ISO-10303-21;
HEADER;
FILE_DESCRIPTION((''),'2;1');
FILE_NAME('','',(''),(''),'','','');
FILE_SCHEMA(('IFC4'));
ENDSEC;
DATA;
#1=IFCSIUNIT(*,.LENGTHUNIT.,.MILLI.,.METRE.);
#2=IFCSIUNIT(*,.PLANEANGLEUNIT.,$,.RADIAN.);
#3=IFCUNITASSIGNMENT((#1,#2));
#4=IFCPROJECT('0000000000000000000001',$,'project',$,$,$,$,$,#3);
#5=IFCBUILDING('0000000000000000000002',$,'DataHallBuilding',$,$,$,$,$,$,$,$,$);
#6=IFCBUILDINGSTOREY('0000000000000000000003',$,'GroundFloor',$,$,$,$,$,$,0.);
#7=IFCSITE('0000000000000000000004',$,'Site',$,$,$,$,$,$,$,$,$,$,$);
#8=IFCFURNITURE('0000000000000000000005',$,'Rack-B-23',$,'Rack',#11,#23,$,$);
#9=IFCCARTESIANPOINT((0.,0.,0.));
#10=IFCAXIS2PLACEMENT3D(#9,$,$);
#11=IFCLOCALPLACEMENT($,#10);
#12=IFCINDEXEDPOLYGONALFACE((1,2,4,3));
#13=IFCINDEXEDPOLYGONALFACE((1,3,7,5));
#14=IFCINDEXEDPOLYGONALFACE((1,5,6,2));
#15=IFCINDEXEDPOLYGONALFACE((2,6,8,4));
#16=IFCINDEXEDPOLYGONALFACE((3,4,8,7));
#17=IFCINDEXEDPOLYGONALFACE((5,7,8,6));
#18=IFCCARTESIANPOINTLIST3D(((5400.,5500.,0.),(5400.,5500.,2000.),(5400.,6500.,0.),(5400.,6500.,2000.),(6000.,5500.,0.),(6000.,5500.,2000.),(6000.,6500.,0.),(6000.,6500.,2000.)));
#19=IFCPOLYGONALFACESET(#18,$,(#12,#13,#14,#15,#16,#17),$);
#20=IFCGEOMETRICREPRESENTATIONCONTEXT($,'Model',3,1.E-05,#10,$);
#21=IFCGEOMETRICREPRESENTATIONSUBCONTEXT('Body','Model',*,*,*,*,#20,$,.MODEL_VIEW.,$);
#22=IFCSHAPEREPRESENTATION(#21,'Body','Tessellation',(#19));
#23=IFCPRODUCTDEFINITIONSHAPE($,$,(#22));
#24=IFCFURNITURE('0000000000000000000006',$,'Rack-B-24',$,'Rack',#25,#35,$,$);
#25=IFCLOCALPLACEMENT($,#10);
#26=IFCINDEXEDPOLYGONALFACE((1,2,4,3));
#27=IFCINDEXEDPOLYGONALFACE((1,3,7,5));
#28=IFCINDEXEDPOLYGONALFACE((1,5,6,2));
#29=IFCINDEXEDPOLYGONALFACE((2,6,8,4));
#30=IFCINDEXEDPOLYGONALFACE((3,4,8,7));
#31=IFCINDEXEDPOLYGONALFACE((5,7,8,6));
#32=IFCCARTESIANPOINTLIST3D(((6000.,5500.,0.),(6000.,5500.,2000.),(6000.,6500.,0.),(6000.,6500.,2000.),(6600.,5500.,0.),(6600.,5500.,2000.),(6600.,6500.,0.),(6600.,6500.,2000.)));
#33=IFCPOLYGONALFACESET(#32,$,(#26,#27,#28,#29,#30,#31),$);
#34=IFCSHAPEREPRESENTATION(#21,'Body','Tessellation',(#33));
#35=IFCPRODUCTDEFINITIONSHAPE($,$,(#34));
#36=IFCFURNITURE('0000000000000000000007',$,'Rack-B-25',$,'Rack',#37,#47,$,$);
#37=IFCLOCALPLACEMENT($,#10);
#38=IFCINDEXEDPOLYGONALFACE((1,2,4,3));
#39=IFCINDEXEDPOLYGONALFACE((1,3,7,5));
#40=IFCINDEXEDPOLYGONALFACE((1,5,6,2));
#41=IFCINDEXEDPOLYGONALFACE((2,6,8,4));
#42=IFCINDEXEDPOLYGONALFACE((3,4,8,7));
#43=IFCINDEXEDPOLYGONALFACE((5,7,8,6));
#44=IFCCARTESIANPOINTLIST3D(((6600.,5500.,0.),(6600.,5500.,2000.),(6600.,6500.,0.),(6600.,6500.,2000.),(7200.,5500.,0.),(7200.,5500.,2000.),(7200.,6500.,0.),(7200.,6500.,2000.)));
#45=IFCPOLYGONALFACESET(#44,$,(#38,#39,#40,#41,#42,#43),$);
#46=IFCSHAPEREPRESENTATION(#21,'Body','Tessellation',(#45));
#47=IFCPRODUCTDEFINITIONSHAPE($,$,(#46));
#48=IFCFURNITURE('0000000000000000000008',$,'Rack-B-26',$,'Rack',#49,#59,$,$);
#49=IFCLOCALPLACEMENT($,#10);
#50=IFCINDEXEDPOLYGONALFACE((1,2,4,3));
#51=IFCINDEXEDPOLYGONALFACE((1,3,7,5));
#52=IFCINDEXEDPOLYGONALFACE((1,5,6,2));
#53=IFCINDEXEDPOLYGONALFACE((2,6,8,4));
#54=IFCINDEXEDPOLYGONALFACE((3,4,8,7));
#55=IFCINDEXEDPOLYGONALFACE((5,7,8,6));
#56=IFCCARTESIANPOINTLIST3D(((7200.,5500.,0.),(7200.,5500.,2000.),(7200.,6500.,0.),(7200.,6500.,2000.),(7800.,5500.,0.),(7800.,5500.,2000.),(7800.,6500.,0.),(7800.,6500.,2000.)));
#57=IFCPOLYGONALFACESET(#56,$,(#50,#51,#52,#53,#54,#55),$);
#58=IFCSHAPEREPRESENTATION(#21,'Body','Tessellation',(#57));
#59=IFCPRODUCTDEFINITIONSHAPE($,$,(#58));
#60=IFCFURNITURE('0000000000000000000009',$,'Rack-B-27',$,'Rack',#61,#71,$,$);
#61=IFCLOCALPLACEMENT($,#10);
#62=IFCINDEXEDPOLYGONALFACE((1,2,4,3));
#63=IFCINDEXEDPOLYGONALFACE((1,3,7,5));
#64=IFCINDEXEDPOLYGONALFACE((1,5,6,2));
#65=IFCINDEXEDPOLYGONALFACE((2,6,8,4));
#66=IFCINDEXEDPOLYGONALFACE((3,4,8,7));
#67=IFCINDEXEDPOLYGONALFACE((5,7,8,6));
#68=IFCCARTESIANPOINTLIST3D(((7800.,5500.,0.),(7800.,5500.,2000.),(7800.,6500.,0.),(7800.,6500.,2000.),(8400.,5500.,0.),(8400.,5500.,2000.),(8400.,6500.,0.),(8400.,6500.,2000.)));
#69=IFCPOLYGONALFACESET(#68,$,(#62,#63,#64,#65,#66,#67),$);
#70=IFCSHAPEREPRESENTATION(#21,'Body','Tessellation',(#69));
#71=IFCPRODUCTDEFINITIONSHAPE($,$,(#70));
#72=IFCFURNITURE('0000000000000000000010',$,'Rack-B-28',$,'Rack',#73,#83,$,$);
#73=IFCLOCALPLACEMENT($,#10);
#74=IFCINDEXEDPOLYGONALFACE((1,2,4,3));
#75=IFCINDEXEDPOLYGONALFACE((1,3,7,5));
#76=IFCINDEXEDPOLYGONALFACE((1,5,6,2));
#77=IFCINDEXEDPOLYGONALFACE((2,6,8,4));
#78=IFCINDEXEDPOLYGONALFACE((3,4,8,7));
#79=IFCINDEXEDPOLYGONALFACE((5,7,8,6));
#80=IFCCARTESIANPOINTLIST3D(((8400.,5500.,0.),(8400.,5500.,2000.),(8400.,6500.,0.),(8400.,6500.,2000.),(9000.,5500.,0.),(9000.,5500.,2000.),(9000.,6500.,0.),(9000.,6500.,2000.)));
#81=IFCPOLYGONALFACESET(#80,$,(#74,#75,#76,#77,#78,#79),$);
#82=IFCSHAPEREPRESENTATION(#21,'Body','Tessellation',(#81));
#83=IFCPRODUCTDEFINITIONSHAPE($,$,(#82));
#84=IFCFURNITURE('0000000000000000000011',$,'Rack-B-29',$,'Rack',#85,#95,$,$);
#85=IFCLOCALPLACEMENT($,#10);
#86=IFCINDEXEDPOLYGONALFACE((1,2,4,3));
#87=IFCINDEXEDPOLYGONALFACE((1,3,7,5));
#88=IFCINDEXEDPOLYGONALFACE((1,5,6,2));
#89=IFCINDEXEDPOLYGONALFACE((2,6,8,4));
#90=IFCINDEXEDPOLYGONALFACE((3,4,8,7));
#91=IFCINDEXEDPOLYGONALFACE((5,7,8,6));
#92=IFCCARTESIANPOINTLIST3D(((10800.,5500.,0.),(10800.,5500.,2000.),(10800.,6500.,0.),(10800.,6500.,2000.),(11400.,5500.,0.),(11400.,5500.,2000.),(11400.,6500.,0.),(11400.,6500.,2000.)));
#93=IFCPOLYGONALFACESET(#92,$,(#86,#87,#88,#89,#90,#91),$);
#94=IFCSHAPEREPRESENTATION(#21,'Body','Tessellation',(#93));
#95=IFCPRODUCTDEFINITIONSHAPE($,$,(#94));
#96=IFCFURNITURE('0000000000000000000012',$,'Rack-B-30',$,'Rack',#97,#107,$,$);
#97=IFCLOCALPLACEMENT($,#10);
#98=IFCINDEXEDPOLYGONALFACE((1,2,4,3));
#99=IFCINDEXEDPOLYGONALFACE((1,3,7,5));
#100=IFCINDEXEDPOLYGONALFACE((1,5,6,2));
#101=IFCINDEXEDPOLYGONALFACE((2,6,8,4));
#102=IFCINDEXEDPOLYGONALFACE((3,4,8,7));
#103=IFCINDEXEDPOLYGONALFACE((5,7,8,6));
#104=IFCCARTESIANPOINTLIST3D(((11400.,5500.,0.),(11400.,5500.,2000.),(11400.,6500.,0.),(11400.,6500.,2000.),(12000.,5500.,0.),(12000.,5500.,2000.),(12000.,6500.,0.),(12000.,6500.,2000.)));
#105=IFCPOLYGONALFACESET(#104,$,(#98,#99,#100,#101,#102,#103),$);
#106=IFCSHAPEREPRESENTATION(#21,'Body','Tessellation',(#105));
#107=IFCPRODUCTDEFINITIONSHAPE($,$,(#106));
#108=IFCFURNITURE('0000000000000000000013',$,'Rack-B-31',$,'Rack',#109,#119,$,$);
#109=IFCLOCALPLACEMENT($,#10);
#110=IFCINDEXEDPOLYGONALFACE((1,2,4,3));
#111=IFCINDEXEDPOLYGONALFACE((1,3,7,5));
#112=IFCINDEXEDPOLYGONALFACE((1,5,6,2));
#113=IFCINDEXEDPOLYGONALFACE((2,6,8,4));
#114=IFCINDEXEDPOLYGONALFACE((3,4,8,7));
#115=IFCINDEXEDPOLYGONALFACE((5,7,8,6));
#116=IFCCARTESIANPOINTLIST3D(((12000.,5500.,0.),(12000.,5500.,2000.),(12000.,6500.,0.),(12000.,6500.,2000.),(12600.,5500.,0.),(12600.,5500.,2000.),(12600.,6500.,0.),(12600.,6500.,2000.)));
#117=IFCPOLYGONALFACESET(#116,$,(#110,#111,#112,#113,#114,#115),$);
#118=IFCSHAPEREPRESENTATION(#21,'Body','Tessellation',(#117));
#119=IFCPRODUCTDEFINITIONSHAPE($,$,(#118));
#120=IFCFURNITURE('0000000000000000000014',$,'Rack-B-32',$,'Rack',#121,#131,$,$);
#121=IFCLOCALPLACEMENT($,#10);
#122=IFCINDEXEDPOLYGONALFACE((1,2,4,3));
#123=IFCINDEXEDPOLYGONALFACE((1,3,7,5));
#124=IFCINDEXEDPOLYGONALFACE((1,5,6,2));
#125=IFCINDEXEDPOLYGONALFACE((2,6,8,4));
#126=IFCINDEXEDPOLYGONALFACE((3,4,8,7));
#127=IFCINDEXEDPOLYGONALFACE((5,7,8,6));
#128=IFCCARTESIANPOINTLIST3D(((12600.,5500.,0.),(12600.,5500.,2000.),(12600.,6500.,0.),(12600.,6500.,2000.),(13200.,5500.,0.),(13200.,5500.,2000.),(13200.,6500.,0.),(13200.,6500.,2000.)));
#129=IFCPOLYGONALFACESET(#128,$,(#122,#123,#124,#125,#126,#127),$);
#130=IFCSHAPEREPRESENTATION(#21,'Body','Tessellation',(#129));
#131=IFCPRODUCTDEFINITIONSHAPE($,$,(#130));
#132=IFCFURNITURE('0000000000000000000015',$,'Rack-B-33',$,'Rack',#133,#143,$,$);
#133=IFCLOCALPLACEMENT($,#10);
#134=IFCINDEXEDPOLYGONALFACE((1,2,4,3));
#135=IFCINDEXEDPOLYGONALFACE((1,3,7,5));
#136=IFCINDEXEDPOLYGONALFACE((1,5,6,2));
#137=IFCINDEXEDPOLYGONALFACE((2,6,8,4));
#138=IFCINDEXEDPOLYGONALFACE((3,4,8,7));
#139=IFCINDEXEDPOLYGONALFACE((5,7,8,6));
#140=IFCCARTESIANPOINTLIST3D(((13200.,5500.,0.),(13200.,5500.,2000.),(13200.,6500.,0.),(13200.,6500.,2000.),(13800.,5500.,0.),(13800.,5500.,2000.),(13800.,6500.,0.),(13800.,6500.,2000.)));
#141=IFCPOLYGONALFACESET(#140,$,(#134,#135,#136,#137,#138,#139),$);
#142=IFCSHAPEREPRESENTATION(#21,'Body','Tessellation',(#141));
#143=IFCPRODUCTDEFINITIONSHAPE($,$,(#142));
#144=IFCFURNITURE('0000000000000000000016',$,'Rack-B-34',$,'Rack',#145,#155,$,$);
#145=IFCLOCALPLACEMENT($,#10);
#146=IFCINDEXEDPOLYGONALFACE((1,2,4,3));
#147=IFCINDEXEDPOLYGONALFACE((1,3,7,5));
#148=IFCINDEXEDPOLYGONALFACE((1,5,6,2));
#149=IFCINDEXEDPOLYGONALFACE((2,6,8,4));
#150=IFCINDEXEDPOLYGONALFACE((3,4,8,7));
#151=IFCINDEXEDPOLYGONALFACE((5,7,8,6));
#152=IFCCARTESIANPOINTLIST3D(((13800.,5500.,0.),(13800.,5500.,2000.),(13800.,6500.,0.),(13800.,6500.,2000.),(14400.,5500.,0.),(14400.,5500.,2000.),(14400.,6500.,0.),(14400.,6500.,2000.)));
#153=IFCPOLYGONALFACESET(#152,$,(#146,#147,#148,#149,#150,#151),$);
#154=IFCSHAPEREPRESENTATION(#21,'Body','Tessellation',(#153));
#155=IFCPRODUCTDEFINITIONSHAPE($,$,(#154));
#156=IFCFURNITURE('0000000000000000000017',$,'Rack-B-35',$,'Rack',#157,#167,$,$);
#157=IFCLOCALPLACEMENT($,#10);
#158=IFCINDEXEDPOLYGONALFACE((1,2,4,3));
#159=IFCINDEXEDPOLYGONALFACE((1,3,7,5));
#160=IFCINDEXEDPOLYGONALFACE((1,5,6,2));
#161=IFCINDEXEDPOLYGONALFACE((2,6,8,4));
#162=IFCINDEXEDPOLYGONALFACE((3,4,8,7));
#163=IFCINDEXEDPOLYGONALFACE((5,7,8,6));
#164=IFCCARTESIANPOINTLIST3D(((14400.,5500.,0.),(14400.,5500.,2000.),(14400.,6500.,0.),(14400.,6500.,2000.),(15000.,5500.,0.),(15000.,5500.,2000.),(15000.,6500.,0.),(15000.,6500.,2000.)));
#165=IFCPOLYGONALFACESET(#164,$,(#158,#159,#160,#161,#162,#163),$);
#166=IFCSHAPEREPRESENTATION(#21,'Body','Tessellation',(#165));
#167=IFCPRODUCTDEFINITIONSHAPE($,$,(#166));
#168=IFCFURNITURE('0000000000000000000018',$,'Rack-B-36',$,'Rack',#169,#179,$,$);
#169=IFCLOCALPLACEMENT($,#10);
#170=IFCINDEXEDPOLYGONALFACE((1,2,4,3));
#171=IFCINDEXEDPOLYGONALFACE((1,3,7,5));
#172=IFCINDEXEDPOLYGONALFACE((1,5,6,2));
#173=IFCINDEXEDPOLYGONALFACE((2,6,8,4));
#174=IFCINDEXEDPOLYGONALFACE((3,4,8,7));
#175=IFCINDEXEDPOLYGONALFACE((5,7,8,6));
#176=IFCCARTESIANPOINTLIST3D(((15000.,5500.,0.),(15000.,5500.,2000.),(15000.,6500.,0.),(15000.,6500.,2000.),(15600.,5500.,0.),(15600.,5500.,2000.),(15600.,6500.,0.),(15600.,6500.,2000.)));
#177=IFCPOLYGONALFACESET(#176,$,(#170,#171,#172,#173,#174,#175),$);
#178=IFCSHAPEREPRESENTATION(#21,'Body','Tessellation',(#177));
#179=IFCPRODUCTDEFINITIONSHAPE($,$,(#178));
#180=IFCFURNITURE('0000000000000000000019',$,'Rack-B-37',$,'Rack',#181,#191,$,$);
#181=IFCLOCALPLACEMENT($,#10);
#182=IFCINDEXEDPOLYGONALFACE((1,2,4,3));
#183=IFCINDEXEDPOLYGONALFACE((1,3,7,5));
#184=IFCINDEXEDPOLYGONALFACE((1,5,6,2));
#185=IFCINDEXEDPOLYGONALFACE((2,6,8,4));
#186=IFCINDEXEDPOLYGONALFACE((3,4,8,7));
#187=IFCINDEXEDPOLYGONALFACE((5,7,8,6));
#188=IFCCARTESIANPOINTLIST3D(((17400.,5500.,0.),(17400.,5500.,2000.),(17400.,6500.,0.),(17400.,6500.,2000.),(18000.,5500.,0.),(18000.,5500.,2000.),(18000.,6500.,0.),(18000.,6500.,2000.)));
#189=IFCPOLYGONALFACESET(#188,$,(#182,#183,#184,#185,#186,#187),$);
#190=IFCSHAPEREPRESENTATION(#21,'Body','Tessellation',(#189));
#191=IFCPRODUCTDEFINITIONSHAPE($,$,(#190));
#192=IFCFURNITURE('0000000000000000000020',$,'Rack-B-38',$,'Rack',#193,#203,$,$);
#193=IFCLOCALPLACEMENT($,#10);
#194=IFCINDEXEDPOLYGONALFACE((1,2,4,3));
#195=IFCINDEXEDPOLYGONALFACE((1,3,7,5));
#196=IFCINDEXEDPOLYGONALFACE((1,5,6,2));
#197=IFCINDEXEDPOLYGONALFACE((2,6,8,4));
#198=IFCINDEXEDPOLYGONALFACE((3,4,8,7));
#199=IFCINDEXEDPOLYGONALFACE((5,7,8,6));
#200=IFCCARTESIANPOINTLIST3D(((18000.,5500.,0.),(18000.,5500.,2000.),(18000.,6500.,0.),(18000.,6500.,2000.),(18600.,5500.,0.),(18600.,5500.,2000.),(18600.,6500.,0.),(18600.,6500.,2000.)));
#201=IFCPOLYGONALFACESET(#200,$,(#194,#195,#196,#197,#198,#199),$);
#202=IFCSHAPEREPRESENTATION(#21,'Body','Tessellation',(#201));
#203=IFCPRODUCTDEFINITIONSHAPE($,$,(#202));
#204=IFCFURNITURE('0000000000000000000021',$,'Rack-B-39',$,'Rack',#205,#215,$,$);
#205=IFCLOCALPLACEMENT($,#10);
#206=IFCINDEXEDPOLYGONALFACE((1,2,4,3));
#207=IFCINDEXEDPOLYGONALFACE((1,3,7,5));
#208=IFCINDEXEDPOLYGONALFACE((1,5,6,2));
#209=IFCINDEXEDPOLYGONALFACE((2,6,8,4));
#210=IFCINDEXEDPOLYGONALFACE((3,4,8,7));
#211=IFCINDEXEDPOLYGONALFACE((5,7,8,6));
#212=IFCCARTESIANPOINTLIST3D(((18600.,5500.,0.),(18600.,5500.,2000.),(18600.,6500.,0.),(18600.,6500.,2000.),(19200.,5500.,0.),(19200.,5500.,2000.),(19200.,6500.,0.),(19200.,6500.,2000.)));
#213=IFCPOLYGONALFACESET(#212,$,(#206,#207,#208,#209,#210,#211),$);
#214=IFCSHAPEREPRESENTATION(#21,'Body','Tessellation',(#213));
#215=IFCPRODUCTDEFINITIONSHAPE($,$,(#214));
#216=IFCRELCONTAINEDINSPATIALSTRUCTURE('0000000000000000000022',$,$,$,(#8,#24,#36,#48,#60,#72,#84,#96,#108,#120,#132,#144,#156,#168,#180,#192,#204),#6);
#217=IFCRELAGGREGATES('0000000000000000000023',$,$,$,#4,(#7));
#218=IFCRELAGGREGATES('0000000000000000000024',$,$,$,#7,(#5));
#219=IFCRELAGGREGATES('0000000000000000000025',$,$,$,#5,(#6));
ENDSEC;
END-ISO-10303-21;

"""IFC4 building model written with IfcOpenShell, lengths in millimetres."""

from ifc_helpers import new_model, si_unit, frame, origin, place, context, subcontext, project, spatial, rectangle, extrude, element, save


model = new_model("IFC4")

# Units and contexts
model_context = context("Model", 3, precision=1e-05, world=origin())
body_context = subcontext(model_context, "Body", "Model", "MODEL_VIEW")
ifc_project = project(units=[si_unit("LENGTHUNIT", "METRE", prefix="MILLI"), si_unit("PLANEANGLEUNIT", "RADIAN")])

# Site, building, storey
site = spatial("IfcSite", under=ifc_project, Name="Site")
building = spatial("IfcBuilding", under=site, Name="DataHallBuilding")
storey = spatial("IfcBuildingStorey", under=building, Name="GroundFloor", Elevation=0.0)

# Furniture
furniture_1_placement = place(None, origin())
element("IfcFurniture", 1, at=furniture_1_placement, inside=storey, Name="Rack-B-23", ObjectType="Rack", context=body_context, shape_type="SweptSolid", body=[
    extrude(rectangle(XDim=600.0, YDim=1000.0), frame((5700.0, 6000.0, 0.0), z_axis=(0.0, 0.0, 1.0), x_axis=(1.0, 0.0, 0.0)), (0.0, 0.0, 1.0), 2000.0),
])
furniture_2_placement = place(None, origin())
element("IfcFurniture", 2, at=furniture_2_placement, inside=storey, Name="Rack-B-24", ObjectType="Rack", context=body_context, shape_type="SweptSolid", body=[
    extrude(rectangle(XDim=600.0, YDim=1000.0), frame((6300.0, 6000.0, 0.0), z_axis=(0.0, 0.0, 1.0), x_axis=(1.0, 0.0, 0.0)), (0.0, 0.0, 1.0), 2000.0),
])
furniture_3_placement = place(None, origin())
element("IfcFurniture", 3, at=furniture_3_placement, inside=storey, Name="Rack-B-25", ObjectType="Rack", context=body_context, shape_type="SweptSolid", body=[
    extrude(rectangle(XDim=600.0, YDim=1000.0), frame((6900.0, 6000.0, 0.0), z_axis=(0.0, 0.0, 1.0), x_axis=(1.0, 0.0, 0.0)), (0.0, 0.0, 1.0), 2000.0),
])
furniture_4_placement = place(None, origin())
element("IfcFurniture", 4, at=furniture_4_placement, inside=storey, Name="Rack-B-26", ObjectType="Rack", context=body_context, shape_type="SweptSolid", body=[
    extrude(rectangle(XDim=600.0, YDim=1000.0), frame((7500.0, 6000.0, 0.0), z_axis=(0.0, 0.0, 1.0), x_axis=(1.0, 0.0, 0.0)), (0.0, 0.0, 1.0), 2000.0),
])
furniture_5_placement = place(None, origin())
element("IfcFurniture", 5, at=furniture_5_placement, inside=storey, Name="Rack-B-27", ObjectType="Rack", context=body_context, shape_type="SweptSolid", body=[
    extrude(rectangle(XDim=600.0, YDim=1000.0), frame((8100.0, 6000.0, 0.0), z_axis=(0.0, 0.0, 1.0), x_axis=(1.0, 0.0, 0.0)), (0.0, 0.0, 1.0), 2000.0),
])
furniture_6_placement = place(None, origin())
element("IfcFurniture", 6, at=furniture_6_placement, inside=storey, Name="Rack-B-28", ObjectType="Rack", context=body_context, shape_type="SweptSolid", body=[
    extrude(rectangle(XDim=600.0, YDim=1000.0), frame((8700.0, 6000.0, 0.0), z_axis=(0.0, 0.0, 1.0), x_axis=(1.0, 0.0, 0.0)), (0.0, 0.0, 1.0), 2000.0),
])
furniture_7_placement = place(None, origin())
element("IfcFurniture", 7, at=furniture_7_placement, inside=storey, Name="Rack-B-29", ObjectType="Rack", context=body_context, shape_type="SweptSolid", body=[
    extrude(rectangle(XDim=600.0, YDim=1000.0), frame((11100.0, 6000.0, 0.0), z_axis=(0.0, 0.0, 1.0), x_axis=(1.0, 0.0, 0.0)), (0.0, 0.0, 1.0), 2000.0),
])
furniture_8_placement = place(None, origin())
element("IfcFurniture", 8, at=furniture_8_placement, inside=storey, Name="Rack-B-30", ObjectType="Rack", context=body_context, shape_type="SweptSolid", body=[
    extrude(rectangle(XDim=600.0, YDim=1000.0), frame((11700.0, 6000.0, 0.0), z_axis=(0.0, 0.0, 1.0), x_axis=(1.0, 0.0, 0.0)), (0.0, 0.0, 1.0), 2000.0),
])
furniture_9_placement = place(None, origin())
element("IfcFurniture", 9, at=furniture_9_placement, inside=storey, Name="Rack-B-31", ObjectType="Rack", context=body_context, shape_type="SweptSolid", body=[
    extrude(rectangle(XDim=600.0, YDim=1000.0), frame((12300.0, 6000.0, 0.0), z_axis=(0.0, 0.0, 1.0), x_axis=(1.0, 0.0, 0.0)), (0.0, 0.0, 1.0), 2000.0),
])
furniture_10_placement = place(None, origin())
element("IfcFurniture", 10, at=furniture_10_placement, inside=storey, Name="Rack-B-32", ObjectType="Rack", context=body_context, shape_type="SweptSolid", body=[
    extrude(rectangle(XDim=600.0, YDim=1000.0), frame((12900.0, 6000.0, 0.0), z_axis=(0.0, 0.0, 1.0), x_axis=(1.0, 0.0, 0.0)), (0.0, 0.0, 1.0), 2000.0),
])
furniture_11_placement = place(None, origin())
element("IfcFurniture", 11, at=furniture_11_placement, inside=storey, Name="Rack-B-33", ObjectType="Rack", context=body_context, shape_type="SweptSolid", body=[
    extrude(rectangle(XDim=600.0, YDim=1000.0), frame((13500.0, 6000.0, 0.0), z_axis=(0.0, 0.0, 1.0), x_axis=(1.0, 0.0, 0.0)), (0.0, 0.0, 1.0), 2000.0),
])
furniture_12_placement = place(None, origin())
element("IfcFurniture", 12, at=furniture_12_placement, inside=storey, Name="Rack-B-34", ObjectType="Rack", context=body_context, shape_type="SweptSolid", body=[
    extrude(rectangle(XDim=600.0, YDim=1000.0), frame((14100.0, 6000.0, 0.0), z_axis=(0.0, 0.0, 1.0), x_axis=(1.0, 0.0, 0.0)), (0.0, 0.0, 1.0), 2000.0),
])
furniture_13_placement = place(None, origin())
element("IfcFurniture", 13, at=furniture_13_placement, inside=storey, Name="Rack-B-35", ObjectType="Rack", context=body_context, shape_type="SweptSolid", body=[
    extrude(rectangle(XDim=600.0, YDim=1000.0), frame((14700.0, 6000.0, 0.0), z_axis=(0.0, 0.0, 1.0), x_axis=(1.0, 0.0, 0.0)), (0.0, 0.0, 1.0), 2000.0),
])
furniture_14_placement = place(None, origin())
element("IfcFurniture", 14, at=furniture_14_placement, inside=storey, Name="Rack-B-36", ObjectType="Rack", context=body_context, shape_type="SweptSolid", body=[
    extrude(rectangle(XDim=600.0, YDim=1000.0), frame((15300.0, 6000.0, 0.0), z_axis=(0.0, 0.0, 1.0), x_axis=(1.0, 0.0, 0.0)), (0.0, 0.0, 1.0), 2000.0),
])
furniture_15_placement = place(None, origin())
element("IfcFurniture", 15, at=furniture_15_placement, inside=storey, Name="Rack-B-37", ObjectType="Rack", context=body_context, shape_type="SweptSolid", body=[
    extrude(rectangle(XDim=600.0, YDim=1000.0), frame((17700.0, 6000.0, 0.0), z_axis=(0.0, 0.0, 1.0), x_axis=(1.0, 0.0, 0.0)), (0.0, 0.0, 1.0), 2000.0),
])
furniture_16_placement = place(None, origin())
element("IfcFurniture", 16, at=furniture_16_placement, inside=storey, Name="Rack-B-38", ObjectType="Rack", context=body_context, shape_type="SweptSolid", body=[
    extrude(rectangle(XDim=600.0, YDim=1000.0), frame((18300.0, 6000.0, 0.0), z_axis=(0.0, 0.0, 1.0), x_axis=(1.0, 0.0, 0.0)), (0.0, 0.0, 1.0), 2000.0),
])
furniture_17_placement = place(None, origin())
element("IfcFurniture", 17, at=furniture_17_placement, inside=storey, Name="Rack-B-39", ObjectType="Rack", context=body_context, shape_type="SweptSolid", body=[
    extrude(rectangle(XDim=600.0, YDim=1000.0), frame((18900.0, 6000.0, 0.0), z_axis=(0.0, 0.0, 1.0), x_axis=(1.0, 0.0, 0.0)), (0.0, 0.0, 1.0), 2000.0),
])

save(model, "model.ifc")
